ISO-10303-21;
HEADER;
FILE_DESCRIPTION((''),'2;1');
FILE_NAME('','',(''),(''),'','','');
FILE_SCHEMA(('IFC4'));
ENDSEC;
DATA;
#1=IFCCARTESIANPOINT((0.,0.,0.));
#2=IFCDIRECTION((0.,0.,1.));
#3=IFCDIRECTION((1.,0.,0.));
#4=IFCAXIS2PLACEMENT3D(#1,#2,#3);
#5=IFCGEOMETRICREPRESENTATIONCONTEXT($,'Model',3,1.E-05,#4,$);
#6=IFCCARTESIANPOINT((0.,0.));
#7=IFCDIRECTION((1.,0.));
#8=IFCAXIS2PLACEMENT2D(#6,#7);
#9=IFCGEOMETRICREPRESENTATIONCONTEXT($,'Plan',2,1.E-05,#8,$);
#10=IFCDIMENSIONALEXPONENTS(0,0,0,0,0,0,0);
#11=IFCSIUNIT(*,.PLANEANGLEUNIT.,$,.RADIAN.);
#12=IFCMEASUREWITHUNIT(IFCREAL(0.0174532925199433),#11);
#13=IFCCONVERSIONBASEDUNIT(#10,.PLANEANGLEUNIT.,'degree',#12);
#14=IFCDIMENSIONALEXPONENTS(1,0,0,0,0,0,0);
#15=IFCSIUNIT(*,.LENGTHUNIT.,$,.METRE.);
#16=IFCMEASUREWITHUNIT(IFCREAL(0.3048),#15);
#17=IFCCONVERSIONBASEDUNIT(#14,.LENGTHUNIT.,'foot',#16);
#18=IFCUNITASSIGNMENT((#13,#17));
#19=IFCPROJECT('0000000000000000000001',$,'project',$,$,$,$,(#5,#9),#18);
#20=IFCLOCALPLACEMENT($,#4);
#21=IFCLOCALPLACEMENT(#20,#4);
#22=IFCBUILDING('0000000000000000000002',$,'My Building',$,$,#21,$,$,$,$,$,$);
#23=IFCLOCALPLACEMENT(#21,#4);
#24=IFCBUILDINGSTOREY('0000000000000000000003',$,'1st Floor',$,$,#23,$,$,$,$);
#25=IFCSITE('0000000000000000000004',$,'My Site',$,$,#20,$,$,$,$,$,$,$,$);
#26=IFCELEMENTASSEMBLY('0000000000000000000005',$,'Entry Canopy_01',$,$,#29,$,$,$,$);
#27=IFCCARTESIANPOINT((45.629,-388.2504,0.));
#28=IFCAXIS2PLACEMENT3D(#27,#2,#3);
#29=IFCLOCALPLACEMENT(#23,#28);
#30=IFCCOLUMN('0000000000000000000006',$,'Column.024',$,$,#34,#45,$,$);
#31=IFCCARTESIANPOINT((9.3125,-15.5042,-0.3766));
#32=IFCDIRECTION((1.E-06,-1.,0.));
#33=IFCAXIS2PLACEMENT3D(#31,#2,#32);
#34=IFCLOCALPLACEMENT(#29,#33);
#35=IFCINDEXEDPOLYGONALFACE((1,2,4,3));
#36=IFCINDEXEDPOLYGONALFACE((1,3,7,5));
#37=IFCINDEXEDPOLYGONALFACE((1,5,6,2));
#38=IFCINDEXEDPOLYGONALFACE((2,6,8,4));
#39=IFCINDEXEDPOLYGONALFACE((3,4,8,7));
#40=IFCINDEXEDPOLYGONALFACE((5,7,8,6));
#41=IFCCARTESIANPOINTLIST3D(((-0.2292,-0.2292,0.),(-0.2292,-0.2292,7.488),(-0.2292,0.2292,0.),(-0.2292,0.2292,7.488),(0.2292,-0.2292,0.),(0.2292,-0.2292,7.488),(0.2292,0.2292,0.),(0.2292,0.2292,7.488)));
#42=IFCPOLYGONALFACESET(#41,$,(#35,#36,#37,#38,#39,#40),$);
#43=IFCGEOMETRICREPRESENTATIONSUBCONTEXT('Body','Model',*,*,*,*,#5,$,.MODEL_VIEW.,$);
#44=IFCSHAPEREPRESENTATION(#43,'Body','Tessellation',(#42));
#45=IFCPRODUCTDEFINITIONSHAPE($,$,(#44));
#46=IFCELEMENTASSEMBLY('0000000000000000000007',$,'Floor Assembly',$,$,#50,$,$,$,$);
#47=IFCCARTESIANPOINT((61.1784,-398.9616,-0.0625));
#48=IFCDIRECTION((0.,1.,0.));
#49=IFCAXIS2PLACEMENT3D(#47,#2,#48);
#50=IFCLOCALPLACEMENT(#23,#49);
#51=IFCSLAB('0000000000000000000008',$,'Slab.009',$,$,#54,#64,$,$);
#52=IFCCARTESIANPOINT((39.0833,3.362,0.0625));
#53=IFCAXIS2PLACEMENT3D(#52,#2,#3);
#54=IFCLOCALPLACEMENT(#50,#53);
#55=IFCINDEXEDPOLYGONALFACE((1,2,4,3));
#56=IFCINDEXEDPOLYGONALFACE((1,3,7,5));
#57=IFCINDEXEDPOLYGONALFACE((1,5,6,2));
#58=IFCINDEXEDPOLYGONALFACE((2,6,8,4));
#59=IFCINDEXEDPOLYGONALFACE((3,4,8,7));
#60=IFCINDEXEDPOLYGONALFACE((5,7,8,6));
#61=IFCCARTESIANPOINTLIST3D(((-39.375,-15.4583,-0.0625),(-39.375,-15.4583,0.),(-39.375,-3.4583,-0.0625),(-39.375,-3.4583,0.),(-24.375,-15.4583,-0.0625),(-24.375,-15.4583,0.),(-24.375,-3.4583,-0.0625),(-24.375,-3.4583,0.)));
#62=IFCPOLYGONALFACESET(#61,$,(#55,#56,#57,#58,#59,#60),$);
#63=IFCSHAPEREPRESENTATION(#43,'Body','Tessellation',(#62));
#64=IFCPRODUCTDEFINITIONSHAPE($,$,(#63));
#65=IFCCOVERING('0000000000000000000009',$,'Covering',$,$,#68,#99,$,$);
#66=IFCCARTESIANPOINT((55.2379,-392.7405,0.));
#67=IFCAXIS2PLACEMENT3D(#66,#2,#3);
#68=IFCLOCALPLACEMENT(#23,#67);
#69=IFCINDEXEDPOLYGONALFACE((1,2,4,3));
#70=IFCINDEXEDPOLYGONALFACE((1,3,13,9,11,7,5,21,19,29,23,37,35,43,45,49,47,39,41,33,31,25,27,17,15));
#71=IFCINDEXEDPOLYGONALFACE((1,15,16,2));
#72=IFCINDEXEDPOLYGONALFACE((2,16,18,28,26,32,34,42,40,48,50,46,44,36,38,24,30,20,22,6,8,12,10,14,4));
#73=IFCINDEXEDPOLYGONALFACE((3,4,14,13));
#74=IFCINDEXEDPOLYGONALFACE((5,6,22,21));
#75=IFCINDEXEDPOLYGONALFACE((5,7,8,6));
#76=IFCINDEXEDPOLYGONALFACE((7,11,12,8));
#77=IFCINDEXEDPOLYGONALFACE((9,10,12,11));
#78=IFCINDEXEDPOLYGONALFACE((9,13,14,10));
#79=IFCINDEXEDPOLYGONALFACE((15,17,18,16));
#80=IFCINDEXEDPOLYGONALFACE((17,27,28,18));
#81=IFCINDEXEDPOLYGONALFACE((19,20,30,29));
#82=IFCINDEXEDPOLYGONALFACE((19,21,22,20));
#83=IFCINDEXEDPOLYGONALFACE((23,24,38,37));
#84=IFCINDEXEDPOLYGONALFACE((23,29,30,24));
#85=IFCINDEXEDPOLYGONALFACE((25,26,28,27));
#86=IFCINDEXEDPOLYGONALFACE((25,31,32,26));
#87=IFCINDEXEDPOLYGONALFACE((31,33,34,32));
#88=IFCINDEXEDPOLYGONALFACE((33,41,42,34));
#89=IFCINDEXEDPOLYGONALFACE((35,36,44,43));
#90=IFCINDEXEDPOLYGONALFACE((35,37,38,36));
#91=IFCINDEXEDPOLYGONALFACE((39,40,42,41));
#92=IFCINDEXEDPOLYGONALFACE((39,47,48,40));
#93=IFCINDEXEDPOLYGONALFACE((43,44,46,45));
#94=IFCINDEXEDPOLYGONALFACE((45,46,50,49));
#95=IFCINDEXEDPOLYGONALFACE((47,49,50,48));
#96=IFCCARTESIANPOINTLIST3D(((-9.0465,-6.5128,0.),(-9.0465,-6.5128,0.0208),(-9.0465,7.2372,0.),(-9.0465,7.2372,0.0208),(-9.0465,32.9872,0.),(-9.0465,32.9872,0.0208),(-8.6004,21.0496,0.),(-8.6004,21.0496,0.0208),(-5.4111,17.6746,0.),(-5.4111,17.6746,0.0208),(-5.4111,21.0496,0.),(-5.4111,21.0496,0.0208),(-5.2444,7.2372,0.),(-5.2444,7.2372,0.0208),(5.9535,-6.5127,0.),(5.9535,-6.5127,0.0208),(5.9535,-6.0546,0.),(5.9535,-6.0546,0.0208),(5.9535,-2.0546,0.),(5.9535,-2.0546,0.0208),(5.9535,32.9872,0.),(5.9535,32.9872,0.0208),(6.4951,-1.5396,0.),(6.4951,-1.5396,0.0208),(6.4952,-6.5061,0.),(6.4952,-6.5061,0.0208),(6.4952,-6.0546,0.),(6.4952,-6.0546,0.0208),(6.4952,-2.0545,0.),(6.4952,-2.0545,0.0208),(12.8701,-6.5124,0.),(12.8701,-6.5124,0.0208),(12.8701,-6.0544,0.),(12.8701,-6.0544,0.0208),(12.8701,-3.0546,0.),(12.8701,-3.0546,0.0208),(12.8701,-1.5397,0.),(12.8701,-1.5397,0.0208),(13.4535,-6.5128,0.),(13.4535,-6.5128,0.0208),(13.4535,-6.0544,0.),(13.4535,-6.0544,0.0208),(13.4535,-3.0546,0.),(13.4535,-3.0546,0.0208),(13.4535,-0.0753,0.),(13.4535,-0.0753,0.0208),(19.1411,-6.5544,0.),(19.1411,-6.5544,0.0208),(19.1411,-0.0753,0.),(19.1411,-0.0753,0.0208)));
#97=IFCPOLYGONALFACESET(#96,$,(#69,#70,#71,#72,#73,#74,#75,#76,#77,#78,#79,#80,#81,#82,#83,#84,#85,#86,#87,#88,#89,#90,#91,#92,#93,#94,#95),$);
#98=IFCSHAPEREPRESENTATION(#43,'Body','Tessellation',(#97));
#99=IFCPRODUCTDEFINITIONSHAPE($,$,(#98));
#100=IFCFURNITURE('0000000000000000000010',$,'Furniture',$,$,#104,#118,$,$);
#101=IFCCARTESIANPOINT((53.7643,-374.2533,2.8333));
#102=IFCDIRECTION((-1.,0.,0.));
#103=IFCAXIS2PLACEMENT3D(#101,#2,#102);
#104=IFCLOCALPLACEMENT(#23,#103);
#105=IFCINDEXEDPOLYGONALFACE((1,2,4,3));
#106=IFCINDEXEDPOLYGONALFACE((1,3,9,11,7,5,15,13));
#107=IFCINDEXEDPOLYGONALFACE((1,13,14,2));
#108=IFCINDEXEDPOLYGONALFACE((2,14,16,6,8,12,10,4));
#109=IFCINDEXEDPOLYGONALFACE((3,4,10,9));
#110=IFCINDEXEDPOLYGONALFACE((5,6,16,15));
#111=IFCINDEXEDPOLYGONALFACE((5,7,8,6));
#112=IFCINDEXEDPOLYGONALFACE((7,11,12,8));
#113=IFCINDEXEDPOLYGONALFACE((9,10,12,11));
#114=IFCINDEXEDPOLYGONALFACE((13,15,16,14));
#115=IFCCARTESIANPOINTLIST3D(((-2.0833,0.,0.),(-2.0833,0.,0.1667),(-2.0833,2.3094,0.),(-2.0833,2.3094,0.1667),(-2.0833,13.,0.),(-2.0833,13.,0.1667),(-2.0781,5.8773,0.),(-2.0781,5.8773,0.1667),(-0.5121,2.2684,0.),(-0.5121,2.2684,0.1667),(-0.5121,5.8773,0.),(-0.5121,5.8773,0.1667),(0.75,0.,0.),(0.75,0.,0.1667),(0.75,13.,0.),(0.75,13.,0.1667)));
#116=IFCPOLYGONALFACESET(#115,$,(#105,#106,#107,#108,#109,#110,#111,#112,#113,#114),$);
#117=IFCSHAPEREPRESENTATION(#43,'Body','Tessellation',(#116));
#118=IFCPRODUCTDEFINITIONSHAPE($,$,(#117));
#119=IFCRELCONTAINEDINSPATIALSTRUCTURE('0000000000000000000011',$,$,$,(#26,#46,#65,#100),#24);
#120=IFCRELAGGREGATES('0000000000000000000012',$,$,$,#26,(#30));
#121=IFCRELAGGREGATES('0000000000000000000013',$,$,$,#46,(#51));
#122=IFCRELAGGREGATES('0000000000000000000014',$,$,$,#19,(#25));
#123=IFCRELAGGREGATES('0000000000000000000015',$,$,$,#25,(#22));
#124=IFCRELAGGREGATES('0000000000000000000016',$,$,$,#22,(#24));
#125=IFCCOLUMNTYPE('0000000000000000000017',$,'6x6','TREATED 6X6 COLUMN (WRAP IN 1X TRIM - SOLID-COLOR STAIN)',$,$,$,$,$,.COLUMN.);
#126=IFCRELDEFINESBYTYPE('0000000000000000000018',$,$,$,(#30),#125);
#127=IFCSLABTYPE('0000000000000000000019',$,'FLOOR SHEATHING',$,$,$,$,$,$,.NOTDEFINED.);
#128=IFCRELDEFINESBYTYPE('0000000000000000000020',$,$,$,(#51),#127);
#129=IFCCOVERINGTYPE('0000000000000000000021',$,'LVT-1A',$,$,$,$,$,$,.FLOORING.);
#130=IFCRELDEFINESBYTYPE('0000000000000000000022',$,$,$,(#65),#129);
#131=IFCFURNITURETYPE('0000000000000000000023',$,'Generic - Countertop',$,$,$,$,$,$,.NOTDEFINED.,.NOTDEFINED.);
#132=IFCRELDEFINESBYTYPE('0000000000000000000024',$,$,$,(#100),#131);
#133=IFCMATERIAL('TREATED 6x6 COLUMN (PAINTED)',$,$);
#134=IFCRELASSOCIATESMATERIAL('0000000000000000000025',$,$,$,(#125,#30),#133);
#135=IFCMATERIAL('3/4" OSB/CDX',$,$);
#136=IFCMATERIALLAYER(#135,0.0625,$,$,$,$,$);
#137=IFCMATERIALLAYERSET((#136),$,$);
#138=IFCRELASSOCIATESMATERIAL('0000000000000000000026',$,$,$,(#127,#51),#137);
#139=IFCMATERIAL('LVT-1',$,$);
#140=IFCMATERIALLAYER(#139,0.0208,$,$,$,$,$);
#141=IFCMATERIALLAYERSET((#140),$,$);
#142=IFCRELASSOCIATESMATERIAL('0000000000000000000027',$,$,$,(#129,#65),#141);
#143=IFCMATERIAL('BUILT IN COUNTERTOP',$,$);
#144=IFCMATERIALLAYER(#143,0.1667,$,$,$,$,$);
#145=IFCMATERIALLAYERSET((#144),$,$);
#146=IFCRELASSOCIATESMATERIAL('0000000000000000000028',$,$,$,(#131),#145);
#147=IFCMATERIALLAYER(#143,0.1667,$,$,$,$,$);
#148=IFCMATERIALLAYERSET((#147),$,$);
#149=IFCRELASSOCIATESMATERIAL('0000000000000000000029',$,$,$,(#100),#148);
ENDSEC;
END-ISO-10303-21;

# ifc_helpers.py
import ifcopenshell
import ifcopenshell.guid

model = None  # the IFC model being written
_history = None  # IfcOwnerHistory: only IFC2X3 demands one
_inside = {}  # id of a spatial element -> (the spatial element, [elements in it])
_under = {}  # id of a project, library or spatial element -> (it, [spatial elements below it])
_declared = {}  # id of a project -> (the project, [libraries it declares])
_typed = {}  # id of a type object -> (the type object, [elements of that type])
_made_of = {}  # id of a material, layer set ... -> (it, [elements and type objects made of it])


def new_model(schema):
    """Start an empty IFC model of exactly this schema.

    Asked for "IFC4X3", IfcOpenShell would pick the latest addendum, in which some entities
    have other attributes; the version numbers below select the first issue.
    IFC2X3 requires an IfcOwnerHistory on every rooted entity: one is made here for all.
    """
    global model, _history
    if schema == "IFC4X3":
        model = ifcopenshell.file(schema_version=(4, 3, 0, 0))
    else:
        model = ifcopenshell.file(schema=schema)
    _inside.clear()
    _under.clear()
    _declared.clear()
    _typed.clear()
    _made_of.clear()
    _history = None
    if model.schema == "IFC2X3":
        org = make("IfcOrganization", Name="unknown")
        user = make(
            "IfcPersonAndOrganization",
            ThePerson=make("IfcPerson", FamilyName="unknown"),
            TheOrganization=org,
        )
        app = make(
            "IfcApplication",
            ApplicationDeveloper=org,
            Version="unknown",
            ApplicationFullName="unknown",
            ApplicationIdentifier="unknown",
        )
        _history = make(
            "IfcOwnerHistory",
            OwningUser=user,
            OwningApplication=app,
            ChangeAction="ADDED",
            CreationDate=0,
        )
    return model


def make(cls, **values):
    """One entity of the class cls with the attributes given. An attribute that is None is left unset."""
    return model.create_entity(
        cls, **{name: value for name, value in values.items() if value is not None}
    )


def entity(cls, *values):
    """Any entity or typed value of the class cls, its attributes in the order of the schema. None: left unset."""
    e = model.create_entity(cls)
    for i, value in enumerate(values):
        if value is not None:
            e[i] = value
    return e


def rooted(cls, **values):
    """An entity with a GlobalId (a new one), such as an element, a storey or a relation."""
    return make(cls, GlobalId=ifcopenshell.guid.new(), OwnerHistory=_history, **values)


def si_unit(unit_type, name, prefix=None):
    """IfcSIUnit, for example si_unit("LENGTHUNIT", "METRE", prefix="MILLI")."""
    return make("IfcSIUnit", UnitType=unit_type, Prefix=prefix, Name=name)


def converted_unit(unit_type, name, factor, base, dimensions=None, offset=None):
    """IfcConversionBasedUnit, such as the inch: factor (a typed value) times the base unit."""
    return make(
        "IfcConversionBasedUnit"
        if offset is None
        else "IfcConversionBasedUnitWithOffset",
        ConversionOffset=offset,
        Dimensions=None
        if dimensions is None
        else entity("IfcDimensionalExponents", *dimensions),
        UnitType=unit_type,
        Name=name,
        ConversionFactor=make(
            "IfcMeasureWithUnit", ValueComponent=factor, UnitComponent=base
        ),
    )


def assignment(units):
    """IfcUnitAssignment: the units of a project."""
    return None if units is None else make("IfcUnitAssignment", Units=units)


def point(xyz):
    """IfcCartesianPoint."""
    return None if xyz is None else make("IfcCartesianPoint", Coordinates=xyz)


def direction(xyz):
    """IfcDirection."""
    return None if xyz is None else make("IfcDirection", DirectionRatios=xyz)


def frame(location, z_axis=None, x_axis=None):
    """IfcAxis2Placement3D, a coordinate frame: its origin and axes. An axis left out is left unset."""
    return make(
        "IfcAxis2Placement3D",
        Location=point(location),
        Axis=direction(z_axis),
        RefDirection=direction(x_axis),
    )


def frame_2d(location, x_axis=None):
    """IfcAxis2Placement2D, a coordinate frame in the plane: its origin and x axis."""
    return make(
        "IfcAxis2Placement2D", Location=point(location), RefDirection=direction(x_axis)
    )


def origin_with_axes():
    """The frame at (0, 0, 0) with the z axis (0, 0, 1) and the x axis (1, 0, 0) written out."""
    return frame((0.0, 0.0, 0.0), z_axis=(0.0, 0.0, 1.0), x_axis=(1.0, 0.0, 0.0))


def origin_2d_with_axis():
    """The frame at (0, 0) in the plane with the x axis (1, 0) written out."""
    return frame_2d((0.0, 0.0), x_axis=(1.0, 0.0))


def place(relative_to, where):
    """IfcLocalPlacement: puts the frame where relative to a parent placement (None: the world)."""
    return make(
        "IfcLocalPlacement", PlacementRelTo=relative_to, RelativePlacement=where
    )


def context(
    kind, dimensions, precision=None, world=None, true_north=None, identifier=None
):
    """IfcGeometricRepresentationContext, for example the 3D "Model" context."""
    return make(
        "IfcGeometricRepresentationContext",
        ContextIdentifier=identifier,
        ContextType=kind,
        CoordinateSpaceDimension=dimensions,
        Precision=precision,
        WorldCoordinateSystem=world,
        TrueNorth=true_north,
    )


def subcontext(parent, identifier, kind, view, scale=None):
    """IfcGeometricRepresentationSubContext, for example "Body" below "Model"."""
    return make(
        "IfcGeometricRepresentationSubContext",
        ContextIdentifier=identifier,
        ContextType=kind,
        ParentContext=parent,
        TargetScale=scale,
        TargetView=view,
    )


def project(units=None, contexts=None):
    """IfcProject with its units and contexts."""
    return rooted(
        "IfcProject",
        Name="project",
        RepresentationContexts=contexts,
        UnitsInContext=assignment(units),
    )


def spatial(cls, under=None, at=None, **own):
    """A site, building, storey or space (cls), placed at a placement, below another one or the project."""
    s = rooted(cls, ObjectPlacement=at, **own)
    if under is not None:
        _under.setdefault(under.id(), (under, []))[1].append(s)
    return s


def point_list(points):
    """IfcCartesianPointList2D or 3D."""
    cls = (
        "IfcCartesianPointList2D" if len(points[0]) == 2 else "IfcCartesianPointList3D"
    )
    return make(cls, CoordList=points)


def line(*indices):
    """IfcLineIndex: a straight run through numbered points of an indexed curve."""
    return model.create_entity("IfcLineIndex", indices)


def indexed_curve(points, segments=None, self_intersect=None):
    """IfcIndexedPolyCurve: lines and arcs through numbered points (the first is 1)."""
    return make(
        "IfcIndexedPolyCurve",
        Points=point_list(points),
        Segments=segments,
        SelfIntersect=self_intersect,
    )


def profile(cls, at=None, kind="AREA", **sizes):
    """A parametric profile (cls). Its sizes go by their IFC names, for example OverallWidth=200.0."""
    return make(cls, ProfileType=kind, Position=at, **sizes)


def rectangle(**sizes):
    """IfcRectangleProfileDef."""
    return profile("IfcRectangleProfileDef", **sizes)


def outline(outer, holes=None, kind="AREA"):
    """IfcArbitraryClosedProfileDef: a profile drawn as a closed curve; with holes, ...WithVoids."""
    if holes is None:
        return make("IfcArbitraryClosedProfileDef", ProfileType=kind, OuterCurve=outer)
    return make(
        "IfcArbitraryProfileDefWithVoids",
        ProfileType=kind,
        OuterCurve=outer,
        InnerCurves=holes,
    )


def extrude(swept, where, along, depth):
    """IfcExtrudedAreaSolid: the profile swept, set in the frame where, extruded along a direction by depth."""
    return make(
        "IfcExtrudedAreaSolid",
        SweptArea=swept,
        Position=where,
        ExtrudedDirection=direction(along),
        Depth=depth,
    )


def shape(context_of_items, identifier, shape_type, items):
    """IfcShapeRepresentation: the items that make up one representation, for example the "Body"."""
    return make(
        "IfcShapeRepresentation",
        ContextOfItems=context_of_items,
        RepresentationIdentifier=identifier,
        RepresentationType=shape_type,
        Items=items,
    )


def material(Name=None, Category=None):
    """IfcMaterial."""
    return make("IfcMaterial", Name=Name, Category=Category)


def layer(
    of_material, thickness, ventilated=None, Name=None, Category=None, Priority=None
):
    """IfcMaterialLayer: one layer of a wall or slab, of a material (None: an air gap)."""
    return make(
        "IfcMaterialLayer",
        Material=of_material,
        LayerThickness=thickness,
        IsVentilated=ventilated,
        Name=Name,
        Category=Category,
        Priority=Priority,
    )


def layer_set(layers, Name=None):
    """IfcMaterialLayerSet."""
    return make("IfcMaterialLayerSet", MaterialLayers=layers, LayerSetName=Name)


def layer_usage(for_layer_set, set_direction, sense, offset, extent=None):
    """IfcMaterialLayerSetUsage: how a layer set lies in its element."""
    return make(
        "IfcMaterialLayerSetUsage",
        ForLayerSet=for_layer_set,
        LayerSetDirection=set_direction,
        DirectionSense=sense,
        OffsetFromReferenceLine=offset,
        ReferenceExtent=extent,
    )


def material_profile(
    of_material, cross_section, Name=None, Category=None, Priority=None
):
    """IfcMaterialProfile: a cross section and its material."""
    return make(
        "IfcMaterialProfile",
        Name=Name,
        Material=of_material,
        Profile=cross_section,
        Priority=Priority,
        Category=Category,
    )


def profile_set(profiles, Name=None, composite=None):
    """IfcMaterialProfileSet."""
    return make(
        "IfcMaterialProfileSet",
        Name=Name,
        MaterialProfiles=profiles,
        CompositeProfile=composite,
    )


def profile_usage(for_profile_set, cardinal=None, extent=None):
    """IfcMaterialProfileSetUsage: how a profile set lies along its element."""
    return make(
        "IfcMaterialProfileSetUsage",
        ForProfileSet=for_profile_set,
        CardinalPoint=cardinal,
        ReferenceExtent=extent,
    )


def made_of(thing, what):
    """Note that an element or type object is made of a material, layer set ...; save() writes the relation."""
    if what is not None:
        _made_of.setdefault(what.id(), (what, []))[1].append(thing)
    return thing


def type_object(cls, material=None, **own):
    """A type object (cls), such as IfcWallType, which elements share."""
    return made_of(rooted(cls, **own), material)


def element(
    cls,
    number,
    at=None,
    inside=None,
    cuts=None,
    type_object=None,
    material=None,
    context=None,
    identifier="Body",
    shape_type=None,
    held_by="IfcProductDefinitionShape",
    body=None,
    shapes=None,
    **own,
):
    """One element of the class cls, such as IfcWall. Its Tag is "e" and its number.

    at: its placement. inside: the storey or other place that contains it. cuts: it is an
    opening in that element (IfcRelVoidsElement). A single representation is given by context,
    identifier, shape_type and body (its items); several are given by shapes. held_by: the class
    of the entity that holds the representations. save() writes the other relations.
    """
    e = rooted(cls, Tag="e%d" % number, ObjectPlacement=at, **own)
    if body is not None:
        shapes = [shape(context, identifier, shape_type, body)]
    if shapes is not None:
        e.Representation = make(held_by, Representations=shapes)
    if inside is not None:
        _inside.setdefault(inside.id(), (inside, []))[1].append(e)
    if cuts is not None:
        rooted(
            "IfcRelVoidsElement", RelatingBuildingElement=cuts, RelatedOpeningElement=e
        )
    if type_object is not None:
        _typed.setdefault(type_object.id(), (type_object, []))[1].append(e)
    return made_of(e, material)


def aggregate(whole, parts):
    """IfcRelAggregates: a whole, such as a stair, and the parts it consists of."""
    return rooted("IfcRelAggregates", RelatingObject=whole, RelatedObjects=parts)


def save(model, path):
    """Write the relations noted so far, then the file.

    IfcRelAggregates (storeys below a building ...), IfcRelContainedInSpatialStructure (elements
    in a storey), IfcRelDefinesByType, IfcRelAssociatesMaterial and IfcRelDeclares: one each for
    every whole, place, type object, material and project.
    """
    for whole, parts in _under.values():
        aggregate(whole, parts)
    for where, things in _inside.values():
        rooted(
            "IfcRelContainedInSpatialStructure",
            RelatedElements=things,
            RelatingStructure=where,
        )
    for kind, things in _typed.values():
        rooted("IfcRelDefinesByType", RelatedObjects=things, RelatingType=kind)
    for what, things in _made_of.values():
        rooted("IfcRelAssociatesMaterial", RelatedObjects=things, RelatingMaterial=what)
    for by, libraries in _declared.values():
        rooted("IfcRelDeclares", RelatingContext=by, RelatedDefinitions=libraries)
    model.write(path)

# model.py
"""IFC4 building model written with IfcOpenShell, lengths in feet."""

from ifc_helpers import new_model, entity, si_unit, converted_unit, frame, origin_with_axes, origin_2d_with_axis, place, context, subcontext, project, spatial, line, indexed_curve, rectangle, outline, extrude, material, layer, layer_set, layer_usage, material_profile, profile_set, profile_usage, type_object, element, aggregate, save


model = new_model("IFC4")

# Units and contexts
model_context = context("Model", 3, precision=1e-05, world=origin_with_axes())
plan_context = context("Plan", 2, precision=1e-05, world=origin_2d_with_axis())
body_context = subcontext(model_context, "Body", "Model", "MODEL_VIEW")
ifc_project = project(units=[converted_unit("PLANEANGLEUNIT", "degree", entity("IfcReal", 0.0174532925199433), si_unit("PLANEANGLEUNIT", "RADIAN"), dimensions=[0, 0, 0, 0, 0, 0, 0]), converted_unit("LENGTHUNIT", "foot", entity("IfcReal", 0.3048), si_unit("LENGTHUNIT", "METRE"), dimensions=[1, 0, 0, 0, 0, 0, 0])], contexts=[model_context, plan_context])

# Site, building, storey
site_placement = place(None, origin_with_axes())
site = spatial("IfcSite", under=ifc_project, at=site_placement, Name="My Site")
building_placement = place(site_placement, origin_with_axes())
building = spatial("IfcBuilding", under=site, at=building_placement, Name="My Building")
storey_placement = place(building_placement, origin_with_axes())
storey = spatial("IfcBuildingStorey", under=building, at=storey_placement, Name="1st Floor")

# Element assembly, column
assembly_1_placement = place(storey_placement, frame((45.629, -388.2504, 0.0), z_axis=(0.0, 0.0, 1.0), x_axis=(1.0, 0.0, 0.0)))
assembly_1 = element("IfcElementAssembly", 1, at=assembly_1_placement, inside=storey, Name="Entry Canopy_01")
ifc_material_1 = material(Name="TREATED 6x6 COLUMN (PAINTED)")
ifc_material_profile_1 = material_profile(ifc_material_1, rectangle(XDim=0.4583, YDim=0.4583))
ifc_profile_set_1 = profile_set([ifc_material_profile_1])
ifc_profile_usage_1 = profile_usage(ifc_profile_set_1, cardinal=5)
ifc_material_profile_2 = material_profile(ifc_material_1, rectangle(XDim=0.4583, YDim=0.4583))
ifc_profile_set_2 = profile_set([ifc_material_profile_2])
column_type = type_object("IfcColumnType", Name="6x6", Description="TREATED 6X6 COLUMN (WRAP IN 1X TRIM - SOLID-COLOR STAIN)", PredefinedType="COLUMN", material=ifc_profile_set_2)
column_placement = place(assembly_1_placement, frame((9.3125, -15.5042, -0.3766), z_axis=(0.0, 0.0, 1.0), x_axis=(0.000001, -1.0, 0.0)))
column = element("IfcColumn", 2, at=column_placement, type_object=column_type, material=ifc_profile_usage_1, Name="Column.024", context=body_context, shape_type="SweptSolid", body=[
    extrude(rectangle(XDim=0.4583, YDim=0.4583), origin_with_axes(), (0.0, 0.0, 1.0), 7.488),
])

aggregate(assembly_1, [column])

# Element assembly, slab
assembly_2_placement = place(storey_placement, frame((61.1784, -398.9616, -0.0625), z_axis=(0.0, 0.0, 1.0), x_axis=(0.0, 1.0, 0.0)))
assembly_2 = element("IfcElementAssembly", 3, at=assembly_2_placement, inside=storey, Name="Floor Assembly")
ifc_material_2 = material(Name="3/4\" OSB/CDX")
ifc_layer_1 = layer(ifc_material_2, 0.0625)
ifc_layer_set_1 = layer_set([ifc_layer_1])
ifc_layer_usage_1 = layer_usage(ifc_layer_set_1, "AXIS3", "POSITIVE", -0.0625)
slab_type = type_object("IfcSlabType", Name="FLOOR SHEATHING", PredefinedType="NOTDEFINED", material=ifc_layer_set_1)
slab_placement = place(assembly_2_placement, frame((39.0833, 3.362, 0.0625), z_axis=(0.0, 0.0, 1.0), x_axis=(1.0, 0.0, 0.0)))
slab = element("IfcSlab", 4, at=slab_placement, type_object=slab_type, material=ifc_layer_usage_1, Name="Slab.009", context=body_context, shape_type="SolidModel", body=[
    extrude(outline(indexed_curve([(-39.375, -15.4583), (-24.375, -15.4583), (-24.375, -3.4583), (-39.375, -3.4583), (-39.375, -15.4583)])), frame((0.0, 0.0, -0.0625), z_axis=(0.0, 0.0, 1.0), x_axis=(1.0, 0.0, 0.0)), (0.0, 0.0, 1.0), 0.0625),
])
aggregate(assembly_2, [slab])

# Covering
ifc_material_3 = material(Name="LVT-1")
ifc_layer_2 = layer(ifc_material_3, 0.0208)
ifc_layer_set_2 = layer_set([ifc_layer_2])
ifc_layer_usage_2 = layer_usage(ifc_layer_set_2, "AXIS3", "POSITIVE", 0.0)
covering_type = type_object("IfcCoveringType", Name="LVT-1A", PredefinedType="FLOORING", material=ifc_layer_set_2)
covering_placement = place(storey_placement, frame((55.2379, -392.7405, 0.0), z_axis=(0.0, 0.0, 1.0), x_axis=(1.0, 0.0, 0.0)))
element("IfcCovering", 5, at=covering_placement, inside=storey, type_object=covering_type, material=ifc_layer_usage_2, Name="Covering", context=body_context, shape_type="SweptSolid", body=[
    extrude(outline(indexed_curve([(13.4535, -6.5128), (19.1411, -6.5544), (19.1411, -0.0753), (13.4535, -0.0753), (13.4535, -3.0546), (12.8701, -3.0546), (12.8701, -1.5397), (6.4951, -1.5396), (6.4952, -2.0545), (5.9535, -2.0546), (5.9535, 32.9872), (-9.0465, 32.9872), (-8.6004, 21.0496), (-5.4111, 21.0496), (-5.4111, 17.6746), (-5.2444, 7.2372), (-9.0465, 7.2372), (-9.0465, -6.5128), (5.9535, -6.5127), (5.9535, -6.0546), (6.4952, -6.0546), (6.4952, -6.5061), (12.8701, -6.5124), (12.8701, -6.0544), (13.4535, -6.0544), (13.4535, -6.5128)])), None, (0.0, 0.0, 1.0), 0.0208),
])

# Furniture
ifc_material_4 = material(Name="BUILT IN COUNTERTOP")
ifc_layer_3 = layer(ifc_material_4, 0.1667)
ifc_layer_set_3 = layer_set([ifc_layer_3])
ifc_layer_usage_3 = layer_usage(ifc_layer_set_3, "AXIS3", "POSITIVE", 0.0)
ifc_layer_4 = layer(ifc_material_4, 0.1667)
ifc_layer_set_4 = layer_set([ifc_layer_4])
furniture_type_1 = type_object("IfcFurnitureType", Name="Generic - Countertop", AssemblyPlace="NOTDEFINED", PredefinedType="NOTDEFINED", material=ifc_layer_set_4)
furniture_1_placement = place(storey_placement, frame((53.7643, -374.2533, 2.8333), z_axis=(0.0, 0.0, 1.0), x_axis=(-1.0, 0.0, 0.0)))
element("IfcFurniture", 6, at=furniture_1_placement, inside=storey, type_object=furniture_type_1, material=ifc_layer_usage_3, Name="Furniture", context=body_context, shape_type="SweptSolid", body=[
    extrude(outline(indexed_curve([(-2.0833, 13.0), (0.75, 13.0), (0.75, 0.0), (-2.0833, 0.0), (-2.0833, 2.3094), (-0.5121, 2.2684), (-0.5121, 5.8773), (-2.0781, 5.8773)], segments=[line(5, 6), line(6, 7), line(7, 8), line(8, 1), line(1, 2), line(2, 3), line(3, 4), line(4, 5)], self_intersect=False)), None, (0.0, 0.0, 1.0), 0.1667),
])

save(model, "model.ifc")
